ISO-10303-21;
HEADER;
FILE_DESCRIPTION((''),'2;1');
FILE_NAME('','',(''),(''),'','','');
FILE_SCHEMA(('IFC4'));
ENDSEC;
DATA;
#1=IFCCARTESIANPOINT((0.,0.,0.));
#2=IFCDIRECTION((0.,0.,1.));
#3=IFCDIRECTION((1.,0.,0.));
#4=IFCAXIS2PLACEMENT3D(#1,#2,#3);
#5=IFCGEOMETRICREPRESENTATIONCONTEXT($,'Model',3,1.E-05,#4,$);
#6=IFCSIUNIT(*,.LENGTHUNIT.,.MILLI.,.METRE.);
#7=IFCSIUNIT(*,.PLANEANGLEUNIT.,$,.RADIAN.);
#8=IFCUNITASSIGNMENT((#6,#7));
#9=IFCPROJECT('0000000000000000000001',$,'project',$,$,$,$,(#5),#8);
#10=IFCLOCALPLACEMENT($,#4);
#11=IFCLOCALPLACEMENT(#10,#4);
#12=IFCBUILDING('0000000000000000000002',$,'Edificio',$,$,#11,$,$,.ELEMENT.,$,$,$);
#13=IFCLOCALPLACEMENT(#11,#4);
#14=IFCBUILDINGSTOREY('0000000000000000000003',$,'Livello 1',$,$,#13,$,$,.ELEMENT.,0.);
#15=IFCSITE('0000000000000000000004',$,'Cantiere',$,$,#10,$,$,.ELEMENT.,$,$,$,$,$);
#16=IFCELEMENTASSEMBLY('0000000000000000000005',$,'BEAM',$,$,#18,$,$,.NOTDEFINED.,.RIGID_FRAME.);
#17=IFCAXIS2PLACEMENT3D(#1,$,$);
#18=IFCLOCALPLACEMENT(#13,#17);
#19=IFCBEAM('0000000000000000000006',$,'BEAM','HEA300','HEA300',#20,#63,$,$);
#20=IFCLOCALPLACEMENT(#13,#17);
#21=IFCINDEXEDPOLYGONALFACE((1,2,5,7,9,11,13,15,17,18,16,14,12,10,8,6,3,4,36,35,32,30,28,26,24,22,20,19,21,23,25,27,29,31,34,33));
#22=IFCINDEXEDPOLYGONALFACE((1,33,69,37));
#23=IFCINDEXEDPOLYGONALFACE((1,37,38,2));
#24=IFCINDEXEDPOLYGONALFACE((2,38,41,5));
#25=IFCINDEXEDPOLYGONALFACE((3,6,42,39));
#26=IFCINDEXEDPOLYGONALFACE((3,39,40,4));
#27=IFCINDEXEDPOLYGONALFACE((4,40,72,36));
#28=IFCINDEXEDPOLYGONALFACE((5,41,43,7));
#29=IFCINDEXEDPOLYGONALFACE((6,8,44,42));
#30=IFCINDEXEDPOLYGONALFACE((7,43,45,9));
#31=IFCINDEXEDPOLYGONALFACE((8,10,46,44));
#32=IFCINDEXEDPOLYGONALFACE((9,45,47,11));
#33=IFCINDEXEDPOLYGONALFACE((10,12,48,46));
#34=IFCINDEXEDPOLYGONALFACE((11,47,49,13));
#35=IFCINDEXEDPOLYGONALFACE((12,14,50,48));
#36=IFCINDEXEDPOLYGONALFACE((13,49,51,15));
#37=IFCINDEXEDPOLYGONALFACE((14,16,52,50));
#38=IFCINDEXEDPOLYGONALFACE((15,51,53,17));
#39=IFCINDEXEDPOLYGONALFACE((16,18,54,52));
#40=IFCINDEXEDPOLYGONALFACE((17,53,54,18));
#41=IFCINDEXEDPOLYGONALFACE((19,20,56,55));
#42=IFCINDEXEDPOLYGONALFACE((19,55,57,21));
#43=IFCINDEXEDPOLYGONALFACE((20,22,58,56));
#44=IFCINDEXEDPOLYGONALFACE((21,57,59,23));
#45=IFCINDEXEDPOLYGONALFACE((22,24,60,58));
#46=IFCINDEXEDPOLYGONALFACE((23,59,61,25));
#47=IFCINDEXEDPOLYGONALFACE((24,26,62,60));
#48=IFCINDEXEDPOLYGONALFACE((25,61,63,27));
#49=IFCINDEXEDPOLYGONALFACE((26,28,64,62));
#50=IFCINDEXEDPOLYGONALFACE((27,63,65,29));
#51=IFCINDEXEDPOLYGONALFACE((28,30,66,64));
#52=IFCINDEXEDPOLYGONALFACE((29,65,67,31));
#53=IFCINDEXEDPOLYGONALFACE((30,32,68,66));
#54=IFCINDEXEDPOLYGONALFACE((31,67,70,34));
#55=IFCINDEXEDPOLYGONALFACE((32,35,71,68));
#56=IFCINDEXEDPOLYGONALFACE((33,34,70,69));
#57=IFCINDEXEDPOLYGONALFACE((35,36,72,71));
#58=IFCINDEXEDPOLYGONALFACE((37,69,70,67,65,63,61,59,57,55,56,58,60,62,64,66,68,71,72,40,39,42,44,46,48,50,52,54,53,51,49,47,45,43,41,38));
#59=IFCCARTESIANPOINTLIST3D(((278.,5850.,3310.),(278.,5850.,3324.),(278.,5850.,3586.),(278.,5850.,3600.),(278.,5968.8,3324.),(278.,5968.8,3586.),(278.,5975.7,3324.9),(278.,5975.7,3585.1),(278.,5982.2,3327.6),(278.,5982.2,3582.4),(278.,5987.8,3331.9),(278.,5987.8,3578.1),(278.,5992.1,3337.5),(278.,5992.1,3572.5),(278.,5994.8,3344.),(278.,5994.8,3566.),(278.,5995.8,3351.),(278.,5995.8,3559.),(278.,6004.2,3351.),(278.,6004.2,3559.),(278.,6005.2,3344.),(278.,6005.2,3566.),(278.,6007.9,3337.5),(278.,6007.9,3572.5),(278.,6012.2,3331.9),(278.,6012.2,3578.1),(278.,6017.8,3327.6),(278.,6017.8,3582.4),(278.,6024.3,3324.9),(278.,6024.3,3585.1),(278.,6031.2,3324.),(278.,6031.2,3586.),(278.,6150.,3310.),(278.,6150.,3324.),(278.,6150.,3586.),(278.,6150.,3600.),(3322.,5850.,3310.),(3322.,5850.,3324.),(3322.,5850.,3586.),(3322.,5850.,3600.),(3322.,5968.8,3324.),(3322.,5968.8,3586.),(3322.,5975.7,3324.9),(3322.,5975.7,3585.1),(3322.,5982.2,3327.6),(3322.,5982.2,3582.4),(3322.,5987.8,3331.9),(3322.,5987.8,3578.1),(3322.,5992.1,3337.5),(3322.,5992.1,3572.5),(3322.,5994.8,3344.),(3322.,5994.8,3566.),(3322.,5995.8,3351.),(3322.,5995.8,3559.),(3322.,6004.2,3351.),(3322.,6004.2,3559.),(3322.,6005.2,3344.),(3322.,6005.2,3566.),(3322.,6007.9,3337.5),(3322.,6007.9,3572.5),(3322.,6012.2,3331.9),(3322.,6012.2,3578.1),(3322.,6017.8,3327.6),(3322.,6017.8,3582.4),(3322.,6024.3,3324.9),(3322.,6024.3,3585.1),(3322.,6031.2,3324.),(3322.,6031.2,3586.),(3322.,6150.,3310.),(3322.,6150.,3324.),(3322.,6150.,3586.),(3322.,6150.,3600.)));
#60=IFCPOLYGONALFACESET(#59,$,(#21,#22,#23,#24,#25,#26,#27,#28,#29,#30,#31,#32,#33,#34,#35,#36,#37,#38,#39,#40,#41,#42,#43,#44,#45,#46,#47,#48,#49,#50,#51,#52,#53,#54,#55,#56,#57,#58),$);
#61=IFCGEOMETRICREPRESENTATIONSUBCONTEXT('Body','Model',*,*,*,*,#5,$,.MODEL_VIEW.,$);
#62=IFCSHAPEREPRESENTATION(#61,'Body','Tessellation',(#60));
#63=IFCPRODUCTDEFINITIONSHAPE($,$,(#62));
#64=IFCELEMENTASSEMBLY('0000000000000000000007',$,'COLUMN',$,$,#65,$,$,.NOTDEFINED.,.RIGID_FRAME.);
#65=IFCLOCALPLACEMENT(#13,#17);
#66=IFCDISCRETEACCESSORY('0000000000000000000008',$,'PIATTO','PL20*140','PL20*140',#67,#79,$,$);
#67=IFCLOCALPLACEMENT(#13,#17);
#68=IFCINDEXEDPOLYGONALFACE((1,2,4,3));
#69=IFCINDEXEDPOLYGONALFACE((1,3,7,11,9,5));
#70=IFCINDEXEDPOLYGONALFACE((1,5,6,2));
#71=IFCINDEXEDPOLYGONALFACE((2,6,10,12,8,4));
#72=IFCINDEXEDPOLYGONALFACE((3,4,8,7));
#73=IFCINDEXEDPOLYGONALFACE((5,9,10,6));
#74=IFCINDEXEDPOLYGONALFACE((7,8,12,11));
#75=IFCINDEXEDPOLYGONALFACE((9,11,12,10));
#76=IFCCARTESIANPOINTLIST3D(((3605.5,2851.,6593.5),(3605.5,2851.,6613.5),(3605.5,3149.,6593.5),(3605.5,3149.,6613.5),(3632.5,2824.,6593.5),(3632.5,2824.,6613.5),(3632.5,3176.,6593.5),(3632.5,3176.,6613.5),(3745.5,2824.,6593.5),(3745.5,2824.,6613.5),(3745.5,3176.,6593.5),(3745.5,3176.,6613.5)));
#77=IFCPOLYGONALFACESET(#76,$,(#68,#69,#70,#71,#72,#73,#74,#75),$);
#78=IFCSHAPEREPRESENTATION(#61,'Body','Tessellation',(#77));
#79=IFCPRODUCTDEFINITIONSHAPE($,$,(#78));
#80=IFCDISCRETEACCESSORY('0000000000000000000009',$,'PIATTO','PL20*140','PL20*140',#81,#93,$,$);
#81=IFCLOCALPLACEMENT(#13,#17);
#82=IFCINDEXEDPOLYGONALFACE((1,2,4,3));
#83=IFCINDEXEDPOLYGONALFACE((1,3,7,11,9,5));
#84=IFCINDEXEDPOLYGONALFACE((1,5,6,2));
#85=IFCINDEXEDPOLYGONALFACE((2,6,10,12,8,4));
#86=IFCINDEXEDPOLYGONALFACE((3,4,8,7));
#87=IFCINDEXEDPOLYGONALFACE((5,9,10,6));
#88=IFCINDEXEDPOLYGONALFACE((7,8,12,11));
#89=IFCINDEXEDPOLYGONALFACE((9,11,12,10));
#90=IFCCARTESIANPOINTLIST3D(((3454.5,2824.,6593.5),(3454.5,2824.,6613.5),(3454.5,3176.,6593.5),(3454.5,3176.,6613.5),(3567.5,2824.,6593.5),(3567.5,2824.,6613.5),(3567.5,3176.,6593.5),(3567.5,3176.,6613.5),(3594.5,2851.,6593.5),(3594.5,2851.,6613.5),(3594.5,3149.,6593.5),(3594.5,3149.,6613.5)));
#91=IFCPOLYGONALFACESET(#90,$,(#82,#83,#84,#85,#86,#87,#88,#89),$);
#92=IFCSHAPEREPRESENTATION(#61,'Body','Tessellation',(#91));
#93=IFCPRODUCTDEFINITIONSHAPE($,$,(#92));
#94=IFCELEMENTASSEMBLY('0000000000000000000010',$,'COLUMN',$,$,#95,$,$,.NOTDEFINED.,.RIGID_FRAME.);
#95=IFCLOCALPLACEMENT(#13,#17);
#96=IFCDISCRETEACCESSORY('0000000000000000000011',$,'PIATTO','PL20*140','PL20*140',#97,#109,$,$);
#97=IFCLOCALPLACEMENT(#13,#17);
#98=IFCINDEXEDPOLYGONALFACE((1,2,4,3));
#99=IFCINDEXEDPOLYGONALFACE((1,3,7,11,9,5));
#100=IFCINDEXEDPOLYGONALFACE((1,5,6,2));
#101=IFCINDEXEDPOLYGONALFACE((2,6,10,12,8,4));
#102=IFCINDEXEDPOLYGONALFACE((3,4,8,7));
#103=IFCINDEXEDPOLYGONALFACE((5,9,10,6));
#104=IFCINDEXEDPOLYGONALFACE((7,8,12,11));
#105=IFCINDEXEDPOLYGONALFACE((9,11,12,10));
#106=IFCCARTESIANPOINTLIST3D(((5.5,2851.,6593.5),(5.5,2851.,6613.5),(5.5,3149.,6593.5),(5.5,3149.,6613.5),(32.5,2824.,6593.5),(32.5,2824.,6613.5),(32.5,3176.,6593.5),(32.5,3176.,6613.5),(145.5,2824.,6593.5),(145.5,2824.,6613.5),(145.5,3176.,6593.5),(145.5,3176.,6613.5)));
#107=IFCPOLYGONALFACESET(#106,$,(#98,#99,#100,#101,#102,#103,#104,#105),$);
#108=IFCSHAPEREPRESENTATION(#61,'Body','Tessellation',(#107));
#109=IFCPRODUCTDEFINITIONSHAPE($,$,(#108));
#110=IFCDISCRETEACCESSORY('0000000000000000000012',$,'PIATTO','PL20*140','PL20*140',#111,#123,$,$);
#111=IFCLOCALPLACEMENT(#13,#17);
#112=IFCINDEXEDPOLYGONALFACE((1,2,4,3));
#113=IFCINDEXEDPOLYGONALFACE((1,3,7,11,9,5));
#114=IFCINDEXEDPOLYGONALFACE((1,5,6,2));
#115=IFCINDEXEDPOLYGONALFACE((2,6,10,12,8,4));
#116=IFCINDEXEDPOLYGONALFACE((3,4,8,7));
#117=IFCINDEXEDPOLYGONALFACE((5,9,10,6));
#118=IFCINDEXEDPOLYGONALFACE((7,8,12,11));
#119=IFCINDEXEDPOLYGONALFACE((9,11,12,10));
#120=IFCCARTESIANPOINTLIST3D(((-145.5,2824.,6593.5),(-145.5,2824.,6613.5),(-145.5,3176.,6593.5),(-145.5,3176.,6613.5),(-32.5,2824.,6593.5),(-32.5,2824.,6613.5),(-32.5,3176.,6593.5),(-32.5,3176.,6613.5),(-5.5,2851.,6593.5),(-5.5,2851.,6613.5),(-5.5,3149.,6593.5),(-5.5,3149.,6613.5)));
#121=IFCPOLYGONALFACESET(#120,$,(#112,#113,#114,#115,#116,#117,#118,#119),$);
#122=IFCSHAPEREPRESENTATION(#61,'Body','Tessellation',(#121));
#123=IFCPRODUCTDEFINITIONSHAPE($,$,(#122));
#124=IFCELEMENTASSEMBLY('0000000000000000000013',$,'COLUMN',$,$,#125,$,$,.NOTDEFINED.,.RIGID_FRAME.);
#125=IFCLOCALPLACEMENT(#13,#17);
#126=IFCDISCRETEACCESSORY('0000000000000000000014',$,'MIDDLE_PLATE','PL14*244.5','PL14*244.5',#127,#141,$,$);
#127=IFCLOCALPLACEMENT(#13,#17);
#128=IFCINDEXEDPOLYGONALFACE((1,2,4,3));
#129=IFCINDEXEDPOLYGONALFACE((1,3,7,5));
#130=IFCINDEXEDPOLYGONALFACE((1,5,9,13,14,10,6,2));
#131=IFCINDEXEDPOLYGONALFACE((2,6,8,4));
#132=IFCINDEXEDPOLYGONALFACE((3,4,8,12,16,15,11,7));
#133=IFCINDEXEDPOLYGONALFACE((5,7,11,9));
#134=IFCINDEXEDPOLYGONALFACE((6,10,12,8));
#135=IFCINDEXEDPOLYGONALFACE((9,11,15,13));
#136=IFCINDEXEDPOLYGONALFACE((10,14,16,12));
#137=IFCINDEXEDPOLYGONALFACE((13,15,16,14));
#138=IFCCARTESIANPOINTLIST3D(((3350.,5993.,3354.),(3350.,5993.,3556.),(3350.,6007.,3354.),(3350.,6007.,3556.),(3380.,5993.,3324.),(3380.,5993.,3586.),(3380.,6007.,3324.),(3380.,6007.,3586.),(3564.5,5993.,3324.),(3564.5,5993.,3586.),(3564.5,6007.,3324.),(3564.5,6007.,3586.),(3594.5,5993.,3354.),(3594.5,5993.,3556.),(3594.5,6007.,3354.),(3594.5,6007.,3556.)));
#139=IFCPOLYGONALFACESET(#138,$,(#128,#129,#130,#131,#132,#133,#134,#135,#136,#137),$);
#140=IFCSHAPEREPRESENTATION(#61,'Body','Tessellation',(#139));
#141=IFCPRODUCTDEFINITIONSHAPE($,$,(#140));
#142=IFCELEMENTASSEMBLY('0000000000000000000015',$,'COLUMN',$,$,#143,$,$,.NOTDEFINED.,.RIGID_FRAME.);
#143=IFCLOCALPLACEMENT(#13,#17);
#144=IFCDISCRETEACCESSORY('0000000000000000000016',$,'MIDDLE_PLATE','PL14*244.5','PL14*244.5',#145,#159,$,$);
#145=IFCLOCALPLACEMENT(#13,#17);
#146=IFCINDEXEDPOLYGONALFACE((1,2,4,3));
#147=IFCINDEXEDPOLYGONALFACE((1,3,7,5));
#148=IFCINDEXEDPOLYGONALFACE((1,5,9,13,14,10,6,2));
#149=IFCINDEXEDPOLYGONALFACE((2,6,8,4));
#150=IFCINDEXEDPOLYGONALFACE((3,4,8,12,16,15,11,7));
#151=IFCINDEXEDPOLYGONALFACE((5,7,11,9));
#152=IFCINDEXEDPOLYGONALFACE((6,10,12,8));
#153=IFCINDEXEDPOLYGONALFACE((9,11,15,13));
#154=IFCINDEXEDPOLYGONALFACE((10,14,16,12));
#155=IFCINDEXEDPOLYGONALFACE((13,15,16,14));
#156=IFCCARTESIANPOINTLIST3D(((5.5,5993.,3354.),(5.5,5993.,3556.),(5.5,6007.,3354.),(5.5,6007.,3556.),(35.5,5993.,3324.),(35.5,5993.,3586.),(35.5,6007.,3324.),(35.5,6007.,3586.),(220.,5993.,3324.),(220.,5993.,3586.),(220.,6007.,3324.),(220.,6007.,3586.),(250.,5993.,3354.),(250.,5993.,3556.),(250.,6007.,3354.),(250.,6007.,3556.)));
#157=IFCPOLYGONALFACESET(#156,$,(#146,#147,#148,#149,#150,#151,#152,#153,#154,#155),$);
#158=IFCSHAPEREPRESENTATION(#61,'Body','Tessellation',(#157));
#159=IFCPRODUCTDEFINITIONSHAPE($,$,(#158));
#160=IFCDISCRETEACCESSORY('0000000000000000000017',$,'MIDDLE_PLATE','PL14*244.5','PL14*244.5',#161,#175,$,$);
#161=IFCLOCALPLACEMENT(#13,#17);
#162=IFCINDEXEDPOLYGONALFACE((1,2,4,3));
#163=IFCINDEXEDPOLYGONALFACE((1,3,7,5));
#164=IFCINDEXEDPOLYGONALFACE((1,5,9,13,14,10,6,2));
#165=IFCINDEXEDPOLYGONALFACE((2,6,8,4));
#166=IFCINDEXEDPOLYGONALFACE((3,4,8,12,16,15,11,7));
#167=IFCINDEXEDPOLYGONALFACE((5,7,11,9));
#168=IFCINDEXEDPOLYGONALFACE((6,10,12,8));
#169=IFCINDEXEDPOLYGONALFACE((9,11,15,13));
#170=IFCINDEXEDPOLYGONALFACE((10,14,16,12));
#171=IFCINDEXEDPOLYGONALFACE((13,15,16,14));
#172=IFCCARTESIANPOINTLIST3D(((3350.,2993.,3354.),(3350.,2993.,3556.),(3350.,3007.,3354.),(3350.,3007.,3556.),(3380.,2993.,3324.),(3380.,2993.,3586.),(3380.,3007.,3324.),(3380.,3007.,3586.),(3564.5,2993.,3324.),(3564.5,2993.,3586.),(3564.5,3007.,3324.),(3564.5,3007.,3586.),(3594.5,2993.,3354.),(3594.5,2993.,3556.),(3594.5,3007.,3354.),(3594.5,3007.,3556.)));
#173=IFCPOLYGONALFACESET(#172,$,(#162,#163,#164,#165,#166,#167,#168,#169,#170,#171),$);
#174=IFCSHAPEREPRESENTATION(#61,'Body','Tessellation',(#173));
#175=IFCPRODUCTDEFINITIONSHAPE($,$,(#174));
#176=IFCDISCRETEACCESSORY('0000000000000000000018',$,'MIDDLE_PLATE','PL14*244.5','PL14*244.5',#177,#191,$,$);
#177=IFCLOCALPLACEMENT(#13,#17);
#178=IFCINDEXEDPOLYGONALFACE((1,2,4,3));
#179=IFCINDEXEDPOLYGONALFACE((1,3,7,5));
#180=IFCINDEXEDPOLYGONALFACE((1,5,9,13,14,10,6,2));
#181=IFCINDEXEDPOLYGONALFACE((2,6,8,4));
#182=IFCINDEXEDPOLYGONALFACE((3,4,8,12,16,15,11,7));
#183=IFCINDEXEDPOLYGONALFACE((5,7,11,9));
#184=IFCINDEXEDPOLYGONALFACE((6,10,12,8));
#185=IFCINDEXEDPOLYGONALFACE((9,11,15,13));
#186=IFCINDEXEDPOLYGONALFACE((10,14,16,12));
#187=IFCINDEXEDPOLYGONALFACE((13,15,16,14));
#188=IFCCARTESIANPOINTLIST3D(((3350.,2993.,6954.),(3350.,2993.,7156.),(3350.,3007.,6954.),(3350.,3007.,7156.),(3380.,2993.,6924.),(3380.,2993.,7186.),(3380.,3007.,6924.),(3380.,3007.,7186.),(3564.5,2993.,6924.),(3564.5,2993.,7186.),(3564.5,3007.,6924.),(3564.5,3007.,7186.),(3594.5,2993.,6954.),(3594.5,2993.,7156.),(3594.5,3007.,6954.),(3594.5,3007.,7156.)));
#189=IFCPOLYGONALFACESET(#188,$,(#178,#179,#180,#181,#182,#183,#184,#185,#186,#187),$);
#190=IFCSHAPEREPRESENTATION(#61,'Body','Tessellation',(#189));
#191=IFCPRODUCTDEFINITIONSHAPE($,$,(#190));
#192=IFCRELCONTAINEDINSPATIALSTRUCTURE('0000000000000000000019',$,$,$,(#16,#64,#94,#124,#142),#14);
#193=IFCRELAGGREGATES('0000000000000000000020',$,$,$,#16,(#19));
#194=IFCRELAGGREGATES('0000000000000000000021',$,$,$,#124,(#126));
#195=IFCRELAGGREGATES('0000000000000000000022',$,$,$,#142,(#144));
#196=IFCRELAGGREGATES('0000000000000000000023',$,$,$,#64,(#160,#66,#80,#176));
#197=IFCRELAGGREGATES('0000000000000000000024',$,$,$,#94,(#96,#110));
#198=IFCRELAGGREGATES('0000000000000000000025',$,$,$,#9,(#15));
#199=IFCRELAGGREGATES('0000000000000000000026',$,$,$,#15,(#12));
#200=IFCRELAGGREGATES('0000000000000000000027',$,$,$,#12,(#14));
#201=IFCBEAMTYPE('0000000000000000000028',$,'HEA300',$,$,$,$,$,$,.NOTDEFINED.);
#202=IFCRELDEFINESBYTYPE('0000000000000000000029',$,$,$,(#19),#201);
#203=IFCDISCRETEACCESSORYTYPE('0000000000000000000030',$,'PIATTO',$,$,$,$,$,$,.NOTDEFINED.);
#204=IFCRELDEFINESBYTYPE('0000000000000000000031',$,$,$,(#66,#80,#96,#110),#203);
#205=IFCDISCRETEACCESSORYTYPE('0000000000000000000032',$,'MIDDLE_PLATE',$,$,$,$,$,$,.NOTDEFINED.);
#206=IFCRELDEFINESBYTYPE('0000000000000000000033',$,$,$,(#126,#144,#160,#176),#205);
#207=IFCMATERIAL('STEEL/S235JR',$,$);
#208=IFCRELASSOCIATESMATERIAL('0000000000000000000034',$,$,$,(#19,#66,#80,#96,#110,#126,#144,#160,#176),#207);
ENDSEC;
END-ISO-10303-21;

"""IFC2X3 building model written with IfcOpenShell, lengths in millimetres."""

from ifc_helpers import new_model, si_unit, frame, origin_with_axes, origin_2d_with_axis, place, context, subcontext, project, spatial, polyline, i_section, outline, extrude, clip, halfspace, material, type_object, element, aggregate, save


model = new_model("IFC2X3")

# Units and contexts
model_context = context("Model", 3, precision=1e-05, world=origin_with_axes())
body_context = subcontext(model_context, "Body", "Model", "MODEL_VIEW")
ifc_project = project(units=[si_unit("LENGTHUNIT", "METRE", prefix="MILLI"), si_unit("PLANEANGLEUNIT", "RADIAN")], contexts=[model_context])

# Site, building, storey
site_placement = place(None, origin_with_axes())
site = spatial("IfcSite", under=ifc_project, at=site_placement, Name="Cantiere", CompositionType="ELEMENT")
building_placement = place(site_placement, origin_with_axes())
building = spatial("IfcBuilding", under=site, at=building_placement, Name="Edificio", CompositionType="ELEMENT")
storey_placement = place(building_placement, origin_with_axes())
storey = spatial("IfcBuildingStorey", under=building, at=storey_placement, Name="Livello 1", CompositionType="ELEMENT", Elevation=0.0)

# Element assembly, beam
assembly_1_placement = place(storey_placement, origin_with_axes())
assembly_1 = element("IfcElementAssembly", 1, at=assembly_1_placement, inside=storey, Name="BEAM", AssemblyPlace="NOTDEFINED", PredefinedType="RIGID_FRAME")
ifc_material_1 = material(Name="STEEL/S235JR")
beam_type = type_object("IfcBeamType", Name="HEA300", PredefinedType="NOTDEFINED")
beam_placement = place(assembly_1_placement, frame((0.0, 6000.0, 3455.0), z_axis=(0.0, 0.0, 1.0), x_axis=(1.0, 0.0, 0.0)))
beam = element("IfcBeam", 2, at=beam_placement, type_object=beam_type, material=ifc_material_1, Name="BEAM", Description="HEA300", ObjectType="HEA300", context=body_context, shape_type="Clipping", body=[
    clip(clip(extrude(i_section(OverallWidth=300.0, OverallDepth=290.0, WebThickness=8.5, FlangeThickness=14.0, FilletRadius=27.0, at=origin_2d_with_axis()), frame((3322.0, 0.0, 0.0), z_axis=(-1.0, 0.0, 0.0), x_axis=(0.0, -1.0, 0.0)), (0.0, 0.0, 1.0), 3044.0), halfspace(frame((3322.0, -150.0, 0.0), z_axis=(1.0, 0.0, 0.0), x_axis=(0.0, 0.0, 1.0)), False)), halfspace(frame((278.0, 150.0, 0.0), z_axis=(-1.0, 0.0, 0.0), x_axis=(0.0, 0.0, 1.0)), False)),
])
aggregate(assembly_1, [beam])

# Element assemblies, discrete accessories
assembly_2_placement = place(storey_placement, origin_with_axes())
assembly_2 = element("IfcElementAssembly", 3, at=assembly_2_placement, inside=storey, Name="COLUMN", AssemblyPlace="NOTDEFINED", PredefinedType="RIGID_FRAME")
discrete_accessory_type_1 = type_object("IfcDiscreteAccessoryType", Name="PIATTO")
discrete_accessory_1_placement = place(assembly_2_placement, frame((3745.5, 3176.0, 6603.5), z_axis=(0.0, 0.0, 1.0), x_axis=(-1.0, 0.0, 0.0)))
discrete_accessory_1 = element("IfcDiscreteAccessory", 4, at=discrete_accessory_1_placement, type_object=discrete_accessory_type_1, material=ifc_material_1, Name="PIATTO", Description="PL20*140", ObjectType="PL20*140", context=body_context, shape_type="SweptSolid", body=[
    extrude(outline(polyline([(0.0, 0.0), (113.0, 0.0), (140.0, 27.0), (140.0, 325.0), (113.0, 352.0), (0.0, 352.0), (0.0, 0.0)])), frame((0.0, 0.0, -10.0), z_axis=(0.0, 0.0, 1.0), x_axis=(1.0, 0.0, 0.0)), (0.0, 0.0, 1.0), 20.0),
])
discrete_accessory_2_placement = place(assembly_2_placement, frame((3454.5, 3176.0, 6603.5), z_axis=(0.0, 0.0, -1.0), x_axis=(1.0, 0.0, 0.0)))
discrete_accessory_2 = element("IfcDiscreteAccessory", 5, at=discrete_accessory_2_placement, type_object=discrete_accessory_type_1, material=ifc_material_1, Name="PIATTO", Description="PL20*140", ObjectType="PL20*140", context=body_context, shape_type="SweptSolid", body=[
    extrude(outline(polyline([(0.0, 0.0), (113.0, 0.0), (140.0, 27.0), (140.0, 325.0), (113.0, 352.0), (0.0, 352.0), (0.0, 0.0)])), frame((0.0, 0.0, -10.0), z_axis=(0.0, 0.0, 1.0), x_axis=(1.0, 0.0, 0.0)), (0.0, 0.0, 1.0), 20.0),
])
assembly_3_placement = place(storey_placement, origin_with_axes())
assembly_3 = element("IfcElementAssembly", 6, at=assembly_3_placement, inside=storey, Name="COLUMN", AssemblyPlace="NOTDEFINED", PredefinedType="RIGID_FRAME")
discrete_accessory_3_placement = place(assembly_3_placement, frame((145.5, 3176.0, 6603.5), z_axis=(0.0, 0.0, 1.0), x_axis=(-1.0, 0.0, 0.0)))
discrete_accessory_3 = element("IfcDiscreteAccessory", 7, at=discrete_accessory_3_placement, type_object=discrete_accessory_type_1, material=ifc_material_1, Name="PIATTO", Description="PL20*140", ObjectType="PL20*140", context=body_context, shape_type="SweptSolid", body=[
    extrude(outline(polyline([(0.0, 0.0), (113.0, 0.0), (140.0, 27.0), (140.0, 325.0), (113.0, 352.0), (0.0, 352.0), (0.0, 0.0)])), frame((0.0, 0.0, -10.0), z_axis=(0.0, 0.0, 1.0), x_axis=(1.0, 0.0, 0.0)), (0.0, 0.0, 1.0), 20.0),
])
discrete_accessory_4_placement = place(assembly_3_placement, frame((-145.5, 3176.0, 6603.5), z_axis=(0.0, 0.0, -1.0), x_axis=(1.0, 0.0, 0.0)))
discrete_accessory_4 = element("IfcDiscreteAccessory", 8, at=discrete_accessory_4_placement, type_object=discrete_accessory_type_1, material=ifc_material_1, Name="PIATTO", Description="PL20*140", ObjectType="PL20*140", context=body_context, shape_type="SweptSolid", body=[
    extrude(outline(polyline([(0.0, 0.0), (113.0, 0.0), (140.0, 27.0), (140.0, 325.0), (113.0, 352.0), (0.0, 352.0), (0.0, 0.0)])), frame((0.0, 0.0, -10.0), z_axis=(0.0, 0.0, 1.0), x_axis=(1.0, 0.0, 0.0)), (0.0, 0.0, 1.0), 20.0),
])

# Element assemblies, discrete accessories
assembly_4_placement = place(storey_placement, origin_with_axes())
assembly_4 = element("IfcElementAssembly", 9, at=assembly_4_placement, inside=storey, Name="COLUMN", AssemblyPlace="NOTDEFINED", PredefinedType="RIGID_FRAME")
discrete_accessory_type_2 = type_object("IfcDiscreteAccessoryType", Name="MIDDLE_PLATE")
discrete_accessory_5_placement = place(assembly_4_placement, frame((3350.0, 6000.0, 3586.0), z_axis=(0.0, 1.0, 0.0), x_axis=(1.0, 0.0, 0.0)))
discrete_accessory_5 = element("IfcDiscreteAccessory", 10, at=discrete_accessory_5_placement, type_object=discrete_accessory_type_2, material=ifc_material_1, Name="MIDDLE_PLATE", Description="PL14*244.5", ObjectType="PL14*244.5", context=body_context, shape_type="SweptSolid", body=[
    extrude(outline(polyline([(0.0, 30.0), (30.0, 0.0), (214.5, 0.0), (244.5, 30.0), (244.5, 232.0), (214.5, 262.0), (30.0, 262.0), (0.0, 232.0), (0.0, 30.0)])), frame((0.0, 0.0, -7.0), z_axis=(0.0, 0.0, 1.0), x_axis=(1.0, 0.0, 0.0)), (0.0, 0.0, 1.0), 14.0),
])
assembly_5_placement = place(storey_placement, origin_with_axes())
assembly_5 = element("IfcElementAssembly", 11, at=assembly_5_placement, inside=storey, Name="COLUMN", AssemblyPlace="NOTDEFINED", PredefinedType="RIGID_FRAME")
discrete_accessory_6_placement = place(assembly_5_placement, frame((250.0, 6000.0, 3586.0), z_axis=(0.0, -1.0, 0.0), x_axis=(-1.0, 0.0, 0.0)))
discrete_accessory_6 = element("IfcDiscreteAccessory", 12, at=discrete_accessory_6_placement, type_object=discrete_accessory_type_2, material=ifc_material_1, Name="MIDDLE_PLATE", Description="PL14*244.5", ObjectType="PL14*244.5", context=body_context, shape_type="SweptSolid", body=[
    extrude(outline(polyline([(0.0, 30.0), (30.0, 0.0), (214.5, 0.0), (244.5, 30.0), (244.5, 232.0), (214.5, 262.0), (30.0, 262.0), (0.0, 232.0), (0.0, 30.0)])), frame((0.0, 0.0, -7.0), z_axis=(0.0, 0.0, 1.0), x_axis=(1.0, 0.0, 0.0)), (0.0, 0.0, 1.0), 14.0),
])

# Discrete accessories
discrete_accessory_7_placement = place(assembly_2_placement, frame((3350.0, 3000.0, 3586.0), z_axis=(0.0, 1.0, 0.0), x_axis=(1.0, 0.0, 0.0)))
discrete_accessory_7 = element("IfcDiscreteAccessory", 13, at=discrete_accessory_7_placement, type_object=discrete_accessory_type_2, material=ifc_material_1, Name="MIDDLE_PLATE", Description="PL14*244.5", ObjectType="PL14*244.5", context=body_context, shape_type="SweptSolid", body=[
    extrude(outline(polyline([(0.0, 30.0), (30.0, 0.0), (214.5, 0.0), (244.5, 30.0), (244.5, 232.0), (214.5, 262.0), (30.0, 262.0), (0.0, 232.0), (0.0, 30.0)])), frame((0.0, 0.0, -7.0), z_axis=(0.0, 0.0, 1.0), x_axis=(1.0, 0.0, 0.0)), (0.0, 0.0, 1.0), 14.0),
])
discrete_accessory_8_placement = place(assembly_2_placement, frame((3350.0, 3000.0, 7186.0), z_axis=(0.0, 1.0, 0.0), x_axis=(1.0, 0.0, 0.0)))
discrete_accessory_8 = element("IfcDiscreteAccessory", 14, at=discrete_accessory_8_placement, type_object=discrete_accessory_type_2, material=ifc_material_1, Name="MIDDLE_PLATE", Description="PL14*244.5", ObjectType="PL14*244.5", context=body_context, shape_type="SweptSolid", body=[
    extrude(outline(polyline([(0.0, 30.0), (30.0, 0.0), (214.5, 0.0), (244.5, 30.0), (244.5, 232.0), (214.5, 262.0), (30.0, 262.0), (0.0, 232.0), (0.0, 30.0)])), frame((0.0, 0.0, -7.0), z_axis=(0.0, 0.0, 1.0), x_axis=(1.0, 0.0, 0.0)), (0.0, 0.0, 1.0), 14.0),
])
aggregate(assembly_4, [discrete_accessory_5])
aggregate(assembly_5, [discrete_accessory_6])
aggregate(assembly_2, [discrete_accessory_7, discrete_accessory_1, discrete_accessory_2, discrete_accessory_8])
aggregate(assembly_3, [discrete_accessory_3, discrete_accessory_4])

save(model, "model.ifc")
